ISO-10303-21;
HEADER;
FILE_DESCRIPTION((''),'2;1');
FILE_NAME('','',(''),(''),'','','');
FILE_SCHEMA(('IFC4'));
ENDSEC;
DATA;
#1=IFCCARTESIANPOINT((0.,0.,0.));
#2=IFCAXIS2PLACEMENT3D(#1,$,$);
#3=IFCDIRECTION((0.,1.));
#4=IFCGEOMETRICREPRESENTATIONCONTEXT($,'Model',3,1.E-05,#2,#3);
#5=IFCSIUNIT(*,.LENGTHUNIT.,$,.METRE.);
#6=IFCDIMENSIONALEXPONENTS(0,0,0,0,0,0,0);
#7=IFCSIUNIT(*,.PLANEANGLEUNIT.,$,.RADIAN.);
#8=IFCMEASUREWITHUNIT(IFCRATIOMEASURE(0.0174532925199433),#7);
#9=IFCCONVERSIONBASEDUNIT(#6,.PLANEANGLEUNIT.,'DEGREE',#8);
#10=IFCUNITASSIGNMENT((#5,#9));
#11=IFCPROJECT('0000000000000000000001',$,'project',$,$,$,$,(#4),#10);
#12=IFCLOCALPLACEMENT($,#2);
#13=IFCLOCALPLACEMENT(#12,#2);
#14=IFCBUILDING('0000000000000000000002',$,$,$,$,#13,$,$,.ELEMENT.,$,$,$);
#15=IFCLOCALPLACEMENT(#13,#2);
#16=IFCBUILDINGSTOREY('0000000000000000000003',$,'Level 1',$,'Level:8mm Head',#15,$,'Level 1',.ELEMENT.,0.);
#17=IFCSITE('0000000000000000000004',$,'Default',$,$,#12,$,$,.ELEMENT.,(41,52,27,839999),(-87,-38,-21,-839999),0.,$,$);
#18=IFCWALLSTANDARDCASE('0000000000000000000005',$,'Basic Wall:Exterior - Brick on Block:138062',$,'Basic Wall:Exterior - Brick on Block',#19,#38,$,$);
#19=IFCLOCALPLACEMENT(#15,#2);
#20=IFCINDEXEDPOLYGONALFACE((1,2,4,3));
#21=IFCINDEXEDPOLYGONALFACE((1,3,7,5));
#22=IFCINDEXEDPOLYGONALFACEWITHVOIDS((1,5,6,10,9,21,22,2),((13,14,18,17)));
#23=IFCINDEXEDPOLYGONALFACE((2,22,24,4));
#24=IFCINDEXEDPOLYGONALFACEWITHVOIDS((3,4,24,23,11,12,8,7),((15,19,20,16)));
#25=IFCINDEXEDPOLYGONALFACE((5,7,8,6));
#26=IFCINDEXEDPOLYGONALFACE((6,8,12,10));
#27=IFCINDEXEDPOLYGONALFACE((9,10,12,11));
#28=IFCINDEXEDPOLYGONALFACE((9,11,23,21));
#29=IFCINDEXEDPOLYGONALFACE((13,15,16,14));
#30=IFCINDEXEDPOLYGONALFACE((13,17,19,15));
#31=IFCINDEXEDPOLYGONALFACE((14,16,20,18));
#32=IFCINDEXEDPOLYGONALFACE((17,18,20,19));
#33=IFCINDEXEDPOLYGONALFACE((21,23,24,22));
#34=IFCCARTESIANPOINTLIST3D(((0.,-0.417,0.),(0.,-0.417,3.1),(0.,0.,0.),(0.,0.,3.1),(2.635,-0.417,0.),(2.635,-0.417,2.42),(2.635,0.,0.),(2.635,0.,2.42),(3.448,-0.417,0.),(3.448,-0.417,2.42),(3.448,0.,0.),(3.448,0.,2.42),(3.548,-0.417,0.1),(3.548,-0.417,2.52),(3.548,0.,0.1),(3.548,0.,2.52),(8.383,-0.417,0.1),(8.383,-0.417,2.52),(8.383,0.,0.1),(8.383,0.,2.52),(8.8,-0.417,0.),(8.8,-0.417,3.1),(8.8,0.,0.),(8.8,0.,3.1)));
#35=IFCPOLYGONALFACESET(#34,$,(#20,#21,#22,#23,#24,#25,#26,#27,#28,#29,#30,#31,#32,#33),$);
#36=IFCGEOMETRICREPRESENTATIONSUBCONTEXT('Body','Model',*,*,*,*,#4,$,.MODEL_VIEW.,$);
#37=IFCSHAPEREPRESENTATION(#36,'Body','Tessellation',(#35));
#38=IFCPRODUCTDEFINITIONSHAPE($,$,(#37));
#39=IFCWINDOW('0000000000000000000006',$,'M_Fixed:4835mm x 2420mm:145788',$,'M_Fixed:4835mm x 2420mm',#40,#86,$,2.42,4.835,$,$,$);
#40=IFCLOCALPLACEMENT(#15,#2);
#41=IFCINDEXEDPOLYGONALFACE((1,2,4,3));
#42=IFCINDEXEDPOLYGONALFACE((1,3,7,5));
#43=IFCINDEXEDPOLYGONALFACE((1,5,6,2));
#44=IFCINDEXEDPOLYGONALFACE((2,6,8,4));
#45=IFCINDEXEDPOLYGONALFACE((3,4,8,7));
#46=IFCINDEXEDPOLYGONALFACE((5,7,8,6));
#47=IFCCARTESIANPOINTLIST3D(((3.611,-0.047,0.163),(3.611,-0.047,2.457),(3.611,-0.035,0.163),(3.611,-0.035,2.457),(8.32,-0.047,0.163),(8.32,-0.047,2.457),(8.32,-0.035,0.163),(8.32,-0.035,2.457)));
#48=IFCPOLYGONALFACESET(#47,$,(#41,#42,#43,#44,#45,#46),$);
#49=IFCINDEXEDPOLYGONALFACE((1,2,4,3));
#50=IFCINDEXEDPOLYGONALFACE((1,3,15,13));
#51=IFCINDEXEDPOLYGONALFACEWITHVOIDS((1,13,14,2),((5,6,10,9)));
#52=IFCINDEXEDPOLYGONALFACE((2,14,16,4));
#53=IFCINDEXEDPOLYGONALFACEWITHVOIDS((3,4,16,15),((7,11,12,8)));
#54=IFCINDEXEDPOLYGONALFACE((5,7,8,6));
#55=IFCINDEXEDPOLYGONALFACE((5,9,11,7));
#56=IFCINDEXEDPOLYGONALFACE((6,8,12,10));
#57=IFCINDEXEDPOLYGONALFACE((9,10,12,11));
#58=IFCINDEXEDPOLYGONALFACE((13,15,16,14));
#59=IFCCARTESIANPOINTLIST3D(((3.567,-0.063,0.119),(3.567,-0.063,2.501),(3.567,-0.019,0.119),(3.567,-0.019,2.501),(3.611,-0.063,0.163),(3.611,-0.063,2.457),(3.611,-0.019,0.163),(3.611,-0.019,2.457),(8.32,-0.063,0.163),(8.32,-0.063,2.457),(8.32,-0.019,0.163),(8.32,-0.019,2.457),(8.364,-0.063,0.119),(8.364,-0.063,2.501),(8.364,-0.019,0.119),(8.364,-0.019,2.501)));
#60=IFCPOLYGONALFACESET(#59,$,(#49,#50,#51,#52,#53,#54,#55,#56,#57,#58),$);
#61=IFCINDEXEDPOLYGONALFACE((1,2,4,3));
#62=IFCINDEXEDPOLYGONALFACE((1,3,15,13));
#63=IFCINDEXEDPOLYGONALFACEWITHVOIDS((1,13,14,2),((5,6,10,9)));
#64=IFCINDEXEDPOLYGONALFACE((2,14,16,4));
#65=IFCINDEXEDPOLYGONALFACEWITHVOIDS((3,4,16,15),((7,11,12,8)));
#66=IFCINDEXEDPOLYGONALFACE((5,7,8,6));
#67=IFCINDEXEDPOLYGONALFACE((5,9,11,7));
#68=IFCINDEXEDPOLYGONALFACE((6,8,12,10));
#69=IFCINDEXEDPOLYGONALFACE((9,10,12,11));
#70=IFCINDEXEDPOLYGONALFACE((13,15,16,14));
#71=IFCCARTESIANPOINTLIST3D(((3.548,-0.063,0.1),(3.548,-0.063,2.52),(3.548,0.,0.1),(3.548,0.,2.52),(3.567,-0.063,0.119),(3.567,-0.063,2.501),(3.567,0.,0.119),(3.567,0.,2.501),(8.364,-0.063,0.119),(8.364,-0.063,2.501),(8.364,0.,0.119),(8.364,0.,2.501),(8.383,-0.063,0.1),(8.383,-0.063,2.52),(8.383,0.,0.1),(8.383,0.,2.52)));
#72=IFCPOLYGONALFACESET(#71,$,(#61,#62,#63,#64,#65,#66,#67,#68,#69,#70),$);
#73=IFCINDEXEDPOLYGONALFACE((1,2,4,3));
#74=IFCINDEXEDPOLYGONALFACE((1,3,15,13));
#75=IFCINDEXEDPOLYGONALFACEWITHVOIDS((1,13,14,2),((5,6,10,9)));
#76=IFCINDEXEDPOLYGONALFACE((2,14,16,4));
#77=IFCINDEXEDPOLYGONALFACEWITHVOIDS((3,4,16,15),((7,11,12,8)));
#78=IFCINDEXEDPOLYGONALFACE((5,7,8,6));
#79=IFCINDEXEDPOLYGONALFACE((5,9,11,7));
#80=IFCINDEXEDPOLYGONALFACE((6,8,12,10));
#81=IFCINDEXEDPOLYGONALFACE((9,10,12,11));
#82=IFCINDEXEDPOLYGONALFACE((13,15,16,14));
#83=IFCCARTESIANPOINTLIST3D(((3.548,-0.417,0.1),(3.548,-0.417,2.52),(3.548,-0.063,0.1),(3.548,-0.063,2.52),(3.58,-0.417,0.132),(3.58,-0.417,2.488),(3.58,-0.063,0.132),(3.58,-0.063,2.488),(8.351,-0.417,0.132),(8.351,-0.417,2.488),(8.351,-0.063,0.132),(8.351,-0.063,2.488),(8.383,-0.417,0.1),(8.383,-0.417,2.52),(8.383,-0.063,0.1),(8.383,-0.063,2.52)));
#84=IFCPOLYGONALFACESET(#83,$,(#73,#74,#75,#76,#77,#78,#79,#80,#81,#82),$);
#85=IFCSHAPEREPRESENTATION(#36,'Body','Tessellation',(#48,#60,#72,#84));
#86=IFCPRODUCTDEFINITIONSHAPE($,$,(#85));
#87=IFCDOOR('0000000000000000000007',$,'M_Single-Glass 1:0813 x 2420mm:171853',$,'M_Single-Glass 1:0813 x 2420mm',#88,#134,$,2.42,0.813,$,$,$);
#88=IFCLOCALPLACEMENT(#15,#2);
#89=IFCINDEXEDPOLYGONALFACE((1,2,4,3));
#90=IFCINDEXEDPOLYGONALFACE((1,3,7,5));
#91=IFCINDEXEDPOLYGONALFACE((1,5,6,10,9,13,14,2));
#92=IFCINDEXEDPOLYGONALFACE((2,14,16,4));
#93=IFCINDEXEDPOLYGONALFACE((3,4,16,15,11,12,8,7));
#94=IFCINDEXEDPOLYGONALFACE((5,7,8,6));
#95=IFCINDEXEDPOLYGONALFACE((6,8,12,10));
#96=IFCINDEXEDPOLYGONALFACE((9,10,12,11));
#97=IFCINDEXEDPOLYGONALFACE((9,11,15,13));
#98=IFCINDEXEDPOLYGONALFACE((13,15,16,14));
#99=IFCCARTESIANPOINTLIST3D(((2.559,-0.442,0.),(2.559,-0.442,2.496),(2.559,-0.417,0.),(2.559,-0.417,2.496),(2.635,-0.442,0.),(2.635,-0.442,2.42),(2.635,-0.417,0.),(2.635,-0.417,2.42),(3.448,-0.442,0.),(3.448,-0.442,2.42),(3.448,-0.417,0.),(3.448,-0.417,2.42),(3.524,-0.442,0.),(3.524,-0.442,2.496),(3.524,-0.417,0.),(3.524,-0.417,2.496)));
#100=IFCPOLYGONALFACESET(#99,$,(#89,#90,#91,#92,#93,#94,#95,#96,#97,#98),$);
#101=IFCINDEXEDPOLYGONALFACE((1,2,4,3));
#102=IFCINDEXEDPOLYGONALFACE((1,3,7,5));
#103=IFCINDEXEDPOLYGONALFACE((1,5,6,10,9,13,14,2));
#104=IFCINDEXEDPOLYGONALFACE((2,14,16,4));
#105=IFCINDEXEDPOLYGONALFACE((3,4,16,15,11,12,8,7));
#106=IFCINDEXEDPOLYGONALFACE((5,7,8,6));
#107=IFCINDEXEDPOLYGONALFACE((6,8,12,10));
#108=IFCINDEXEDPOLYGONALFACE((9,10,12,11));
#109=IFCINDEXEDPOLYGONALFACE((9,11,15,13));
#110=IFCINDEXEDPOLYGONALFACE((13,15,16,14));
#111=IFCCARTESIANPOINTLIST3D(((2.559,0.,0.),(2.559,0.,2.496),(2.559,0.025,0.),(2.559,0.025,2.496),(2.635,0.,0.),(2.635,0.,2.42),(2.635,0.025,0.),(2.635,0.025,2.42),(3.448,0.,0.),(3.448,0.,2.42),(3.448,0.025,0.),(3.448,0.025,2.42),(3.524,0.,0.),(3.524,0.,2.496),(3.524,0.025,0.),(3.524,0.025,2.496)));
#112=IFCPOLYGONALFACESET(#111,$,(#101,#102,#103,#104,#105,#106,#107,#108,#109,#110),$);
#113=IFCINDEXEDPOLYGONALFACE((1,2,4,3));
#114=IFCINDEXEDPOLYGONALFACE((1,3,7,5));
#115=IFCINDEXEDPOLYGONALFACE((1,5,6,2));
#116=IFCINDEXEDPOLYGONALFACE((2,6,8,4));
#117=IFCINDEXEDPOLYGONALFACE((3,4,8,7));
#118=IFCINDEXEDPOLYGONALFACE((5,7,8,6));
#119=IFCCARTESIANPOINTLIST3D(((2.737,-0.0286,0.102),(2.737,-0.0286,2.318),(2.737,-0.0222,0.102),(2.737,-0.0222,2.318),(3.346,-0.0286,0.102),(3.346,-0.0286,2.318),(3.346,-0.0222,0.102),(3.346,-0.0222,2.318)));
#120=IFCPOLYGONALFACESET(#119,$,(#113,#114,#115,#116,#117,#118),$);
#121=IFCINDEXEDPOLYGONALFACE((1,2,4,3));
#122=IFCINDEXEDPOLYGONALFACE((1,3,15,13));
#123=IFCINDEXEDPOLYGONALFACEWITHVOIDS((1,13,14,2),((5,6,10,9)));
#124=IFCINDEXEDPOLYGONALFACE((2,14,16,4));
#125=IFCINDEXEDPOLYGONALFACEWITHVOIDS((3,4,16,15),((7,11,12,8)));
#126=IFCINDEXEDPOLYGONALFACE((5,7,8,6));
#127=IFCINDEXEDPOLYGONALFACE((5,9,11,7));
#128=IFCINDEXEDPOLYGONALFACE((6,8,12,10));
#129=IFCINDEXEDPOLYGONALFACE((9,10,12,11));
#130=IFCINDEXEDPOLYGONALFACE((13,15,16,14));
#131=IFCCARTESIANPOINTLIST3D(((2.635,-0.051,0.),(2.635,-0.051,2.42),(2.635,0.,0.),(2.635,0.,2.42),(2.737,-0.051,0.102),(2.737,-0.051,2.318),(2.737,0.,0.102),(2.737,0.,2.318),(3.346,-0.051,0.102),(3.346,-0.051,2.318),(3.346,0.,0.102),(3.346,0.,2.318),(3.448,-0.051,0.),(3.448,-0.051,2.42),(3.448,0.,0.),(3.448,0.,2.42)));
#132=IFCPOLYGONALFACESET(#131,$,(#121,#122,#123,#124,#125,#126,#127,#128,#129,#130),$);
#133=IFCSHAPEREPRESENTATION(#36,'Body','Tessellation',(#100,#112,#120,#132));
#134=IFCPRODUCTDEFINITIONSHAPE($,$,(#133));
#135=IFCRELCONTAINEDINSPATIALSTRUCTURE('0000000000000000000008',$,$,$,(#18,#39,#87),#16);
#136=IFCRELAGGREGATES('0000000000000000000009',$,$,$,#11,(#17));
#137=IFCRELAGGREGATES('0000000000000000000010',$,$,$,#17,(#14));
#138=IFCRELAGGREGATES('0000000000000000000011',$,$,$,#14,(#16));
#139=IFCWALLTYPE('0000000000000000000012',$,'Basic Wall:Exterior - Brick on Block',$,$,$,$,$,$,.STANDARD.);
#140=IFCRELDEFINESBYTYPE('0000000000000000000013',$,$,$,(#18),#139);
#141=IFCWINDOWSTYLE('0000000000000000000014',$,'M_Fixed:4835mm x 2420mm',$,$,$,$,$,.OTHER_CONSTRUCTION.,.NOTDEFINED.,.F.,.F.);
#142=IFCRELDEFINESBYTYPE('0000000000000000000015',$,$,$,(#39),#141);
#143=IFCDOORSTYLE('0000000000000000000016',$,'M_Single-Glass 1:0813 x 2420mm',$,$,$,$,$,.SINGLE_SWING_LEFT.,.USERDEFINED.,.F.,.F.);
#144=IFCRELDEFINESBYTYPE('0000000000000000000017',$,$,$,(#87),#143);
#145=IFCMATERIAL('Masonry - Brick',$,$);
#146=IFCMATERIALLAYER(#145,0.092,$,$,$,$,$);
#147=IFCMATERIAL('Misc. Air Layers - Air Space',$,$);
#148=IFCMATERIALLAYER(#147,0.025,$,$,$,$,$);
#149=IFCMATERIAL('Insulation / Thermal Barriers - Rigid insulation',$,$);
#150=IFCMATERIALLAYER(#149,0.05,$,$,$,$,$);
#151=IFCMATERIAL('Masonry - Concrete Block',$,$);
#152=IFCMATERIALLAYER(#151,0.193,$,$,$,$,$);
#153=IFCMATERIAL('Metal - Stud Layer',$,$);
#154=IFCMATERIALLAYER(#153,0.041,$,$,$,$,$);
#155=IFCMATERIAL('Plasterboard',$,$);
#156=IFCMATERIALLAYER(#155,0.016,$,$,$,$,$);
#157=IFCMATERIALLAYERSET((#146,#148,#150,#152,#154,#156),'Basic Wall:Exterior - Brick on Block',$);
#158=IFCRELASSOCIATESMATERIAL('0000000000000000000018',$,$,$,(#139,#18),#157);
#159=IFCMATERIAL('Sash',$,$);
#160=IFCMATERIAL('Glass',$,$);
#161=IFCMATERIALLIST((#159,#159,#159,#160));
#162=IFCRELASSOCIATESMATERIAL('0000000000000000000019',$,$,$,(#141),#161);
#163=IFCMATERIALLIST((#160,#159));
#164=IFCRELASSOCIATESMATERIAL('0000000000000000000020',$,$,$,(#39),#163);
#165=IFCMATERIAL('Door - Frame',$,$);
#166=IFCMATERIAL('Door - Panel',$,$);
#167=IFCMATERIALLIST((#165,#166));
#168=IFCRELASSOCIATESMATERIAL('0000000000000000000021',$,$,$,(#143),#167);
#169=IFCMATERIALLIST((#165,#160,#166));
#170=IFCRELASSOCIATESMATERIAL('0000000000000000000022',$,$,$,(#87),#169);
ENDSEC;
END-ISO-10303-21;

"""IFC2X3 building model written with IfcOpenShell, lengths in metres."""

from ifc_helpers import new_model, entity, si_unit, converted_unit, direction, frame, frame_2d, origin, origin_2d_with_axis, place, context, subcontext, project, spatial, polyline, rectangle, outline, extrude, source, transform, mapped, material, material_list, layer, layer_set, layer_usage, type_object, type_shapes, element, fill, save


model = new_model("IFC2X3")

# Units and contexts
model_context = context("Model", 3, precision=1e-05, world=origin(), true_north=direction((0.0, 1.0)))
body_context = subcontext(model_context, "Body", "Model", "MODEL_VIEW")
ifc_project = project(units=[si_unit("LENGTHUNIT", "METRE"), converted_unit("PLANEANGLEUNIT", "DEGREE", entity("IfcRatioMeasure", 0.0174532925199433), si_unit("PLANEANGLEUNIT", "RADIAN"), dimensions=[0, 0, 0, 0, 0, 0, 0])], contexts=[model_context])

# Site, building, storey
site_placement = place(None, origin())
site = spatial("IfcSite", under=ifc_project, at=site_placement, Name="Default", CompositionType="ELEMENT", RefLatitude=(41, 52, 27, 839999), RefLongitude=(-87, -38, -21, -839999), RefElevation=0.0)
building_placement = place(site_placement, origin())
building = spatial("IfcBuilding", under=site, at=building_placement, CompositionType="ELEMENT")
storey_placement = place(building_placement, origin())
storey = spatial("IfcBuildingStorey", under=building, at=storey_placement, Name="Level 1", ObjectType="Level:8mm Head", LongName="Level 1", CompositionType="ELEMENT", Elevation=0.0)

# Wall, openings, window, door
ifc_material_1 = material(Name="Masonry - Brick")
ifc_layer_1 = layer(ifc_material_1, 0.092)
ifc_material_2 = material(Name="Misc. Air Layers - Air Space")
ifc_layer_2 = layer(ifc_material_2, 0.025)
ifc_material_3 = material(Name="Insulation / Thermal Barriers - Rigid insulation")
ifc_layer_3 = layer(ifc_material_3, 0.05)
ifc_material_4 = material(Name="Masonry - Concrete Block")
ifc_layer_4 = layer(ifc_material_4, 0.193)
ifc_material_5 = material(Name="Metal - Stud Layer")
ifc_layer_5 = layer(ifc_material_5, 0.041)
ifc_material_6 = material(Name="Plasterboard")
ifc_layer_6 = layer(ifc_material_6, 0.016)
ifc_layer_set_1 = layer_set([ifc_layer_1, ifc_layer_2, ifc_layer_3, ifc_layer_4, ifc_layer_5, ifc_layer_6], Name="Basic Wall:Exterior - Brick on Block")
ifc_layer_usage_1 = layer_usage(ifc_layer_set_1, "AXIS2", "NEGATIVE", 0.2085)
wall_type_1 = type_object("IfcWallType", Name="Basic Wall:Exterior - Brick on Block", PredefinedType="STANDARD", material=ifc_layer_set_1)
wall_1_placement = place(storey_placement, frame((0.0, -0.2085, 0.0)))
wall_1 = element("IfcWallStandardCase", 1, at=wall_1_placement, inside=storey, type_object=wall_type_1, material=ifc_layer_usage_1, Name="Basic Wall:Exterior - Brick on Block:138062", ObjectType="Basic Wall:Exterior - Brick on Block", context=body_context, shape_type="SweptSolid", body=[
    extrude(rectangle(XDim=8.8, YDim=0.417, at=frame_2d((4.4, 0.0), x_axis=(-1.0, 0.0))), origin(), (0.0, 0.0, 1.0), 3.1),
])
opening_1_placement = place(wall_1_placement, frame((2.635, -0.2085, 0.0)))
opening_1 = element("IfcOpeningElement", 2, at=opening_1_placement, cuts=wall_1, ObjectType="Opening", context=body_context, shape_type="SweptSolid", body=[
    extrude(rectangle(XDim=0.813, YDim=2.42, at=frame_2d((1.21, 0.4065), x_axis=(0.0, -1.0))), frame((0.0, 0.0, 0.0), z_axis=(0.0, 1.0, 0.0), x_axis=(0.0, 0.0, 1.0)), (0.0, 0.0, 1.0), 0.417),
])
opening_2_placement = place(wall_1_placement, frame((3.548, -0.2085, 0.1)))
opening_2 = element("IfcOpeningElement", 3, at=opening_2_placement, cuts=wall_1, ObjectType="Opening", context=body_context, shape_type="SweptSolid", body=[
    extrude(rectangle(XDim=2.42, YDim=4.835, at=frame_2d((1.21, 2.4175), x_axis=(1.0, 0.0))), frame((0.0, 0.0, 0.0), z_axis=(0.0, 1.0, 0.0), x_axis=(0.0, 0.0, 1.0)), (0.0, 0.0, 1.0), 0.417),
])
ifc_material_7 = material(Name="Glass")
ifc_material_8 = material(Name="Sash")
ifc_material_list_1 = material_list([ifc_material_7, ifc_material_8])
ifc_material_list_2 = material_list([ifc_material_8, ifc_material_8, ifc_material_8, ifc_material_7])
window_style_1 = type_object("IfcWindowStyle", Name="M_Fixed:4835mm x 2420mm", ConstructionType="OTHER_CONSTRUCTION", OperationType="NOTDEFINED", ParameterTakesPrecedence=False, Sizeable=False, material=ifc_material_list_2)
shared_shape_1 = source(origin(), body_context, "Body", "SweptSolid", [
    extrude(rectangle(XDim=0.012, YDim=4.709, at=origin_2d_with_axis()), frame((2.4175, 0.376, 0.063), z_axis=(0.0, 0.0, 1.0), x_axis=(0.0, -1.0, 0.0)), (0.0, 0.0, 1.0), 2.294),
    extrude(outline(polyline([(-2.3985, -1.191), (2.3985, -1.191), (2.3985, 1.191), (-2.3985, 1.191), (-2.3985, -1.191)]), holes=[polyline([(-2.3545, -1.147), (-2.3545, 1.147), (2.3545, 1.147), (2.3545, -1.147), (-2.3545, -1.147)])]), frame((2.4175, 0.354, 1.21), z_axis=(0.0, 1.0, 0.0), x_axis=(1.0, 0.0, 0.0)), (0.0, 0.0, 1.0), 0.044),
    extrude(outline(polyline([(-2.4175, -1.21), (2.4175, -1.21), (2.4175, 1.21), (-2.4175, 1.21), (-2.4175, -1.21)]), holes=[polyline([(-2.3985, -1.191), (-2.3985, 1.191), (2.3985, 1.191), (2.3985, -1.191), (-2.3985, -1.191)])]), frame((2.4175, 0.354, 1.21), z_axis=(0.0, 1.0, 0.0), x_axis=(1.0, 0.0, 0.0)), (0.0, 0.0, 1.0), 0.063),
    extrude(outline(polyline([(-2.4175, -1.21), (2.4175, -1.21), (2.4175, 1.21), (-2.4175, 1.21), (-2.4175, -1.21)]), holes=[polyline([(-2.3855, -1.178), (-2.3855, 1.178), (2.3855, 1.178), (2.3855, -1.178), (-2.3855, -1.178)])]), frame((2.4175, 0.0, 1.21), z_axis=(0.0, 1.0, 0.0), x_axis=(1.0, 0.0, 0.0)), (0.0, 0.0, 1.0), 0.354),
])
type_shapes(window_style_1, [shared_shape_1])
window_1_placement = place(opening_2_placement, origin())
window_1 = element("IfcWindow", 4, at=window_1_placement, inside=storey, type_object=window_style_1, material=ifc_material_list_1, Name="M_Fixed:4835mm x 2420mm:145788", ObjectType="M_Fixed:4835mm x 2420mm", OverallHeight=2.42, OverallWidth=4.835, context=body_context, shape_type="MappedRepresentation", body=[
    mapped(shared_shape_1, transform((0.0, 0.0, 0.0), scale=1.0)),
])
fill(opening_2, window_1)
ifc_material_9 = material(Name="Door - Frame")
ifc_material_10 = material(Name="Door - Panel")
ifc_material_list_3 = material_list([ifc_material_9, ifc_material_7, ifc_material_10])
ifc_material_list_4 = material_list([ifc_material_9, ifc_material_10])
door_style_1 = type_object("IfcDoorStyle", Name="M_Single-Glass 1:0813 x 2420mm", ConstructionType="USERDEFINED", OperationType="SINGLE_SWING_LEFT", ParameterTakesPrecedence=False, Sizeable=False, material=ifc_material_list_4)
shared_shape_2 = source(origin(), body_context, "Body", "SweptSolid", [
    extrude(outline(polyline([(-0.4065, -1.191), (-0.4065, 1.229), (-0.4825, 1.229), (-0.4825, -1.267), (0.4825, -1.267), (0.4825, 1.229), (0.4065, 1.229), (0.4065, -1.191), (-0.4065, -1.191)])), frame((0.4065, 0.0, 1.229), z_axis=(0.0, 1.0, 0.0), x_axis=(1.0, 0.0, 0.0)), (0.0, 0.0, -1.0), 0.025),
    extrude(outline(polyline([(-0.4065, -1.191), (-0.4065, 1.229), (-0.4825, 1.229), (-0.4825, -1.267), (0.4825, -1.267), (0.4825, 1.229), (0.4065, 1.229), (0.4065, -1.191), (-0.4065, -1.191)])), frame((0.4065, 0.442, 1.229), z_axis=(0.0, 1.0, 0.0), x_axis=(1.0, 0.0, 0.0)), (0.0, 0.0, -1.0), 0.025),
    extrude(rectangle(XDim=0.609, YDim=0.0064, at=frame_2d((0.0, 0.0), x_axis=(1.0, 0.0))), frame((0.4065, 0.3916, 0.102)), (0.0, 0.0, 1.0), 2.216),
    extrude(outline(polyline([(-1.21, -0.4065), (1.21, -0.4065), (1.21, 0.4065), (-1.21, 0.4065), (-1.21, -0.4065)]), holes=[polyline([(-1.108, 0.3045), (1.108, 0.3045), (1.108, -0.3045), (-1.108, -0.3045), (-1.108, 0.3045)])]), frame((0.4065, 0.417, 1.21), z_axis=(0.0, -1.0, 0.0), x_axis=(0.0, 0.0, -1.0)), (0.0, 0.0, 1.0), 0.051),
])
type_shapes(door_style_1, [shared_shape_2])
door_1_placement = place(opening_1_placement, origin())
door_1 = element("IfcDoor", 5, at=door_1_placement, inside=storey, type_object=door_style_1, material=ifc_material_list_3, Name="M_Single-Glass 1:0813 x 2420mm:171853", ObjectType="M_Single-Glass 1:0813 x 2420mm", OverallHeight=2.42, OverallWidth=0.813, context=body_context, shape_type="MappedRepresentation", body=[
    mapped(shared_shape_2, transform((0.0, 0.0, 0.0), scale=1.0)),
])
fill(opening_1, door_1)

save(model, "model.ifc")
